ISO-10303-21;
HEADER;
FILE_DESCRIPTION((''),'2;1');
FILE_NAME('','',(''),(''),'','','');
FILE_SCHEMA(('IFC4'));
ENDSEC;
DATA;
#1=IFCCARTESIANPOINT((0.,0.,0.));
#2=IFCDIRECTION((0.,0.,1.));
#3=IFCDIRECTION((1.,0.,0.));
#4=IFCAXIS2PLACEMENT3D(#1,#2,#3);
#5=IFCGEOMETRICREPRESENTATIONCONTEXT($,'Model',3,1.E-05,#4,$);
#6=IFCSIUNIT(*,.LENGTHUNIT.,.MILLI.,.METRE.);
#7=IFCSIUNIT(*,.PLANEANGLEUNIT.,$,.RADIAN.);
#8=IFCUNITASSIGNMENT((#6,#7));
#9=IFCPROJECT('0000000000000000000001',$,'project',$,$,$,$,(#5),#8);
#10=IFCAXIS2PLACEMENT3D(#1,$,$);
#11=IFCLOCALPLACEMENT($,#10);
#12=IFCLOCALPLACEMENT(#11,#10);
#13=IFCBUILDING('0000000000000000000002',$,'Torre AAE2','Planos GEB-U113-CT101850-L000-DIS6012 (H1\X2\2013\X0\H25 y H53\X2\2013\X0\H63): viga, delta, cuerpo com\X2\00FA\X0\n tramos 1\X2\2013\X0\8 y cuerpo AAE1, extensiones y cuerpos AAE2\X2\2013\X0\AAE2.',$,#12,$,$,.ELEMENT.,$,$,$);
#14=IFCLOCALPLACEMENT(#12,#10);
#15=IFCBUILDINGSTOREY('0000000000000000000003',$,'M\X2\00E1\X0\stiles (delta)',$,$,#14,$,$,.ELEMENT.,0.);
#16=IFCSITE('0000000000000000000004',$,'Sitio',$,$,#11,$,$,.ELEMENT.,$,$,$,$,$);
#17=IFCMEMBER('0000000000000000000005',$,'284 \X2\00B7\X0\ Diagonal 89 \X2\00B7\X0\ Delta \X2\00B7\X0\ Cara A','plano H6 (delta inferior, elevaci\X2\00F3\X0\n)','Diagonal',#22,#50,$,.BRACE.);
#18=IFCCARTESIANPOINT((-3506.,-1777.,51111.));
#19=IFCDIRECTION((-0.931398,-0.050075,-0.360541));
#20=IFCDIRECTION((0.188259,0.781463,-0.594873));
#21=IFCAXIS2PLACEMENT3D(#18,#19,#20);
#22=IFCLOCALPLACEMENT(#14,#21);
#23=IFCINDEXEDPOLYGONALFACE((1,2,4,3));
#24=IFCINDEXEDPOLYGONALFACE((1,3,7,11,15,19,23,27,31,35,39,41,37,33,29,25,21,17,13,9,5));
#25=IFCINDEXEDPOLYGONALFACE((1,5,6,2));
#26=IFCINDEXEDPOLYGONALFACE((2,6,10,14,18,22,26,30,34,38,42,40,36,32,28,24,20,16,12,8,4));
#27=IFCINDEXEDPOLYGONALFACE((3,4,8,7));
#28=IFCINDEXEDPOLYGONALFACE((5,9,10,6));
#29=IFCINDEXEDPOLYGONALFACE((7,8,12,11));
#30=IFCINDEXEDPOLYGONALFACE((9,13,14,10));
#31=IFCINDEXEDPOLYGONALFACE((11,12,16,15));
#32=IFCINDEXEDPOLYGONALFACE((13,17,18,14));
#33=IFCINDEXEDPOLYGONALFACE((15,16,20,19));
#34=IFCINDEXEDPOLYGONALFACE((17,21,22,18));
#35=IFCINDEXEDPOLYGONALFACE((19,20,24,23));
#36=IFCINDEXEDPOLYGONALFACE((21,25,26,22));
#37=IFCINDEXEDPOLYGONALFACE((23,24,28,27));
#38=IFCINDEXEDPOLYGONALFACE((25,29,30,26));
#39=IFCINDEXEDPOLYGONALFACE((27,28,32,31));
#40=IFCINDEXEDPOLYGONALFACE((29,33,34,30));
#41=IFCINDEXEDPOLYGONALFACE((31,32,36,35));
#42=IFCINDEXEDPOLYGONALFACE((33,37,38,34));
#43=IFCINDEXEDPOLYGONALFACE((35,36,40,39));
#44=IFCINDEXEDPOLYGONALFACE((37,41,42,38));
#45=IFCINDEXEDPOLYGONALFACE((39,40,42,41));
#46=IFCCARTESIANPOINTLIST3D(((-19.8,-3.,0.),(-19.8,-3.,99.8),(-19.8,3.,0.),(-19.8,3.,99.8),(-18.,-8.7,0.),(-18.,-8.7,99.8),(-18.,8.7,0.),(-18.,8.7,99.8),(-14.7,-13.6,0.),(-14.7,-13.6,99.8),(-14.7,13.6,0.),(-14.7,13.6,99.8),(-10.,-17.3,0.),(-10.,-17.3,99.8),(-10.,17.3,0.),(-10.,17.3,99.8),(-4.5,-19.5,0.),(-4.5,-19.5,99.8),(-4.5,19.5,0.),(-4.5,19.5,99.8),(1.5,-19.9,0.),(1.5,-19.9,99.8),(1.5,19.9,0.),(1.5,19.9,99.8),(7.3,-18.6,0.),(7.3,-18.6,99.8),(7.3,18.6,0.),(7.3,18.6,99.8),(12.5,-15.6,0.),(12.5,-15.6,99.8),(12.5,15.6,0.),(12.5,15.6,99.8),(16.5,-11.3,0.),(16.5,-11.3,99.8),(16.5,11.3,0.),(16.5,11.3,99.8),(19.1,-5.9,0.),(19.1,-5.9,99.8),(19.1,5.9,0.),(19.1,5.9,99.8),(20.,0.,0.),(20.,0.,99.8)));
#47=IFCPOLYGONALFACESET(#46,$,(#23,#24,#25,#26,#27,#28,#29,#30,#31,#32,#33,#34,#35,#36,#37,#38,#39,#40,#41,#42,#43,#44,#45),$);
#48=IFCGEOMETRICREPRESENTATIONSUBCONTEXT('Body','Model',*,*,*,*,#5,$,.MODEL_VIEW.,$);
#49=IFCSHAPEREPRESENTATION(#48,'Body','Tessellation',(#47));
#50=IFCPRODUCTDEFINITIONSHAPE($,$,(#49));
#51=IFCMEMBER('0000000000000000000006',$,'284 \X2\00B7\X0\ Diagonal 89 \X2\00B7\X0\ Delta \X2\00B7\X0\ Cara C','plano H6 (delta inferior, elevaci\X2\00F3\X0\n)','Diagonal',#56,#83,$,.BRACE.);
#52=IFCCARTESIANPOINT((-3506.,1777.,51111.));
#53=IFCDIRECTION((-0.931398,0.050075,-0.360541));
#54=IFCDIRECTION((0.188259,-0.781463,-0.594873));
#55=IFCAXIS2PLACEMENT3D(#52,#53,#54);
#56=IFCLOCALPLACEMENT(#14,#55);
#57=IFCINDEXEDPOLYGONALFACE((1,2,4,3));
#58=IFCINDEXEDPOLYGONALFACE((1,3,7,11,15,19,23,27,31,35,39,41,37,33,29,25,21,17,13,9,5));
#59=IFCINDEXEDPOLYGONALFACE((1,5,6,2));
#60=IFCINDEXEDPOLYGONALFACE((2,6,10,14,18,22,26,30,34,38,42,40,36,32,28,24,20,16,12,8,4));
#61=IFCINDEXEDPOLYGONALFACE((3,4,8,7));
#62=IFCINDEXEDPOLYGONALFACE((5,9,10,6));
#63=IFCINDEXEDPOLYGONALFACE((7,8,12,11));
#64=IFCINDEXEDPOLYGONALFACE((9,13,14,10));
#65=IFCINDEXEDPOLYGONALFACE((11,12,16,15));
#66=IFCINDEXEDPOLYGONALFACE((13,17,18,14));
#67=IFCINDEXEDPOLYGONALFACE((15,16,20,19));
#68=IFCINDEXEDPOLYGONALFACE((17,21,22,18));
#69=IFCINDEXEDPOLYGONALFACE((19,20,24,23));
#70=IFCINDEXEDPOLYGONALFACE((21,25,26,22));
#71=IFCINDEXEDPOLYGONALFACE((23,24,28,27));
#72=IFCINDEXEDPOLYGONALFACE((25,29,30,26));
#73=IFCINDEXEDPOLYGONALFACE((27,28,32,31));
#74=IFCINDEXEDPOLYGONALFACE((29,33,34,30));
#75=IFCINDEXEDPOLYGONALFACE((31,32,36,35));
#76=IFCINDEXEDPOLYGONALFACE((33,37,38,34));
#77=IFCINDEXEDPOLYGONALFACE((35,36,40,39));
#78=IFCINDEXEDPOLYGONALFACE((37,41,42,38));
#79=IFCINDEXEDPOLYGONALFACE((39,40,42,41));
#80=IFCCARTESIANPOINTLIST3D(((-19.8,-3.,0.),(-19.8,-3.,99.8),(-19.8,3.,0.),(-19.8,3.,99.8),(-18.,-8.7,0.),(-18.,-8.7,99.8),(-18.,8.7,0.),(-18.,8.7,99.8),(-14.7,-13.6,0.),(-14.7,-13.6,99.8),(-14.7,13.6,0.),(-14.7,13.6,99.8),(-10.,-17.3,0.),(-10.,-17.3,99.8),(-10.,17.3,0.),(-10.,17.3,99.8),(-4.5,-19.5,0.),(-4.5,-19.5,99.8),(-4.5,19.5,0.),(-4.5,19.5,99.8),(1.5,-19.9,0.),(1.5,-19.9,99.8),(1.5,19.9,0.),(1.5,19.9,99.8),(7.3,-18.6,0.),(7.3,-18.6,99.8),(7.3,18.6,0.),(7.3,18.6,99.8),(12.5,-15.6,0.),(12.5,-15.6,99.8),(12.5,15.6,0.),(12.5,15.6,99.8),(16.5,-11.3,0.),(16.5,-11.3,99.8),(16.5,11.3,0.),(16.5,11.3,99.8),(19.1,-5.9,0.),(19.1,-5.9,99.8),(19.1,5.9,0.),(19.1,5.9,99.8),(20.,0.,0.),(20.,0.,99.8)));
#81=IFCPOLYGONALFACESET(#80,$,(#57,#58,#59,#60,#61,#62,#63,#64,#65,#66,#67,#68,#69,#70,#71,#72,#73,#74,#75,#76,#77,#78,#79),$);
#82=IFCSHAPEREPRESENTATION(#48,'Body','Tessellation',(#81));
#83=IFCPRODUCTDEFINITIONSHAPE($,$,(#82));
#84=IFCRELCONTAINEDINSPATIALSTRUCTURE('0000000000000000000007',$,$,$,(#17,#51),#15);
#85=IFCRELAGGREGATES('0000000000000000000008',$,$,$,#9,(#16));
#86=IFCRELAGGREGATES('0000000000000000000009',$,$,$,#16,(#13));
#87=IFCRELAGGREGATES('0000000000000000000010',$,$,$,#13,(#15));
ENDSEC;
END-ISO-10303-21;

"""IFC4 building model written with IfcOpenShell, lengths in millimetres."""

from ifc_helpers import new_model, si_unit, frame, origin, origin_with_axes, place, context, subcontext, project, spatial, circle, extrude, element, save


model = new_model("IFC4")

# Units and contexts
model_context = context("Model", 3, precision=1e-05, world=origin_with_axes())
body_context = subcontext(model_context, "Body", "Model", "MODEL_VIEW")
ifc_project = project(units=[si_unit("LENGTHUNIT", "METRE", prefix="MILLI"), si_unit("PLANEANGLEUNIT", "RADIAN")], contexts=[model_context])

# Site, building, storey
site_placement = place(None, origin())
site = spatial("IfcSite", under=ifc_project, at=site_placement, Name="Sitio", CompositionType="ELEMENT")
building_placement = place(site_placement, origin())
building = spatial("IfcBuilding", under=site, at=building_placement, Name="Torre AAE2", Description="Planos GEB-U113-CT101850-L000-DIS6012 (H1–H25 y H53–H63): viga, delta, cuerpo común tramos 1–8 y cuerpo AAE1, extensiones y cuerpos AAE2–AAE2.", CompositionType="ELEMENT")
storey_placement = place(building_placement, origin())
storey = spatial("IfcBuildingStorey", under=building, at=storey_placement, Name="Mástiles (delta)", CompositionType="ELEMENT", Elevation=0.0)

# Members
for number, where, z_axis, x_axis, name in (
    (1, (-3506.0, -1777.0, 51111.0), (-0.931398, -0.050075, -0.360541), (0.188259, 0.781463, -0.594873), "284 · Diagonal 89 · Delta · Cara A"),
    (2, (-3506.0, 1777.0, 51111.0), (-0.931398, 0.050075, -0.360541), (0.188259, -0.781463, -0.594873), "284 · Diagonal 89 · Delta · Cara C"),
):
    element("IfcMember", number, at=place(storey_placement, frame(where, z_axis=z_axis, x_axis=x_axis)), inside=storey, Name=name, Description="plano H6 (delta inferior, elevación)", ObjectType="Diagonal", PredefinedType="BRACE", context=body_context, shape_type="SweptSolid", body=[
        extrude(circle(Radius=20.0), None, (0.0, 0.0, 1.0), 99.8),
    ])

save(model, "model.ifc")
